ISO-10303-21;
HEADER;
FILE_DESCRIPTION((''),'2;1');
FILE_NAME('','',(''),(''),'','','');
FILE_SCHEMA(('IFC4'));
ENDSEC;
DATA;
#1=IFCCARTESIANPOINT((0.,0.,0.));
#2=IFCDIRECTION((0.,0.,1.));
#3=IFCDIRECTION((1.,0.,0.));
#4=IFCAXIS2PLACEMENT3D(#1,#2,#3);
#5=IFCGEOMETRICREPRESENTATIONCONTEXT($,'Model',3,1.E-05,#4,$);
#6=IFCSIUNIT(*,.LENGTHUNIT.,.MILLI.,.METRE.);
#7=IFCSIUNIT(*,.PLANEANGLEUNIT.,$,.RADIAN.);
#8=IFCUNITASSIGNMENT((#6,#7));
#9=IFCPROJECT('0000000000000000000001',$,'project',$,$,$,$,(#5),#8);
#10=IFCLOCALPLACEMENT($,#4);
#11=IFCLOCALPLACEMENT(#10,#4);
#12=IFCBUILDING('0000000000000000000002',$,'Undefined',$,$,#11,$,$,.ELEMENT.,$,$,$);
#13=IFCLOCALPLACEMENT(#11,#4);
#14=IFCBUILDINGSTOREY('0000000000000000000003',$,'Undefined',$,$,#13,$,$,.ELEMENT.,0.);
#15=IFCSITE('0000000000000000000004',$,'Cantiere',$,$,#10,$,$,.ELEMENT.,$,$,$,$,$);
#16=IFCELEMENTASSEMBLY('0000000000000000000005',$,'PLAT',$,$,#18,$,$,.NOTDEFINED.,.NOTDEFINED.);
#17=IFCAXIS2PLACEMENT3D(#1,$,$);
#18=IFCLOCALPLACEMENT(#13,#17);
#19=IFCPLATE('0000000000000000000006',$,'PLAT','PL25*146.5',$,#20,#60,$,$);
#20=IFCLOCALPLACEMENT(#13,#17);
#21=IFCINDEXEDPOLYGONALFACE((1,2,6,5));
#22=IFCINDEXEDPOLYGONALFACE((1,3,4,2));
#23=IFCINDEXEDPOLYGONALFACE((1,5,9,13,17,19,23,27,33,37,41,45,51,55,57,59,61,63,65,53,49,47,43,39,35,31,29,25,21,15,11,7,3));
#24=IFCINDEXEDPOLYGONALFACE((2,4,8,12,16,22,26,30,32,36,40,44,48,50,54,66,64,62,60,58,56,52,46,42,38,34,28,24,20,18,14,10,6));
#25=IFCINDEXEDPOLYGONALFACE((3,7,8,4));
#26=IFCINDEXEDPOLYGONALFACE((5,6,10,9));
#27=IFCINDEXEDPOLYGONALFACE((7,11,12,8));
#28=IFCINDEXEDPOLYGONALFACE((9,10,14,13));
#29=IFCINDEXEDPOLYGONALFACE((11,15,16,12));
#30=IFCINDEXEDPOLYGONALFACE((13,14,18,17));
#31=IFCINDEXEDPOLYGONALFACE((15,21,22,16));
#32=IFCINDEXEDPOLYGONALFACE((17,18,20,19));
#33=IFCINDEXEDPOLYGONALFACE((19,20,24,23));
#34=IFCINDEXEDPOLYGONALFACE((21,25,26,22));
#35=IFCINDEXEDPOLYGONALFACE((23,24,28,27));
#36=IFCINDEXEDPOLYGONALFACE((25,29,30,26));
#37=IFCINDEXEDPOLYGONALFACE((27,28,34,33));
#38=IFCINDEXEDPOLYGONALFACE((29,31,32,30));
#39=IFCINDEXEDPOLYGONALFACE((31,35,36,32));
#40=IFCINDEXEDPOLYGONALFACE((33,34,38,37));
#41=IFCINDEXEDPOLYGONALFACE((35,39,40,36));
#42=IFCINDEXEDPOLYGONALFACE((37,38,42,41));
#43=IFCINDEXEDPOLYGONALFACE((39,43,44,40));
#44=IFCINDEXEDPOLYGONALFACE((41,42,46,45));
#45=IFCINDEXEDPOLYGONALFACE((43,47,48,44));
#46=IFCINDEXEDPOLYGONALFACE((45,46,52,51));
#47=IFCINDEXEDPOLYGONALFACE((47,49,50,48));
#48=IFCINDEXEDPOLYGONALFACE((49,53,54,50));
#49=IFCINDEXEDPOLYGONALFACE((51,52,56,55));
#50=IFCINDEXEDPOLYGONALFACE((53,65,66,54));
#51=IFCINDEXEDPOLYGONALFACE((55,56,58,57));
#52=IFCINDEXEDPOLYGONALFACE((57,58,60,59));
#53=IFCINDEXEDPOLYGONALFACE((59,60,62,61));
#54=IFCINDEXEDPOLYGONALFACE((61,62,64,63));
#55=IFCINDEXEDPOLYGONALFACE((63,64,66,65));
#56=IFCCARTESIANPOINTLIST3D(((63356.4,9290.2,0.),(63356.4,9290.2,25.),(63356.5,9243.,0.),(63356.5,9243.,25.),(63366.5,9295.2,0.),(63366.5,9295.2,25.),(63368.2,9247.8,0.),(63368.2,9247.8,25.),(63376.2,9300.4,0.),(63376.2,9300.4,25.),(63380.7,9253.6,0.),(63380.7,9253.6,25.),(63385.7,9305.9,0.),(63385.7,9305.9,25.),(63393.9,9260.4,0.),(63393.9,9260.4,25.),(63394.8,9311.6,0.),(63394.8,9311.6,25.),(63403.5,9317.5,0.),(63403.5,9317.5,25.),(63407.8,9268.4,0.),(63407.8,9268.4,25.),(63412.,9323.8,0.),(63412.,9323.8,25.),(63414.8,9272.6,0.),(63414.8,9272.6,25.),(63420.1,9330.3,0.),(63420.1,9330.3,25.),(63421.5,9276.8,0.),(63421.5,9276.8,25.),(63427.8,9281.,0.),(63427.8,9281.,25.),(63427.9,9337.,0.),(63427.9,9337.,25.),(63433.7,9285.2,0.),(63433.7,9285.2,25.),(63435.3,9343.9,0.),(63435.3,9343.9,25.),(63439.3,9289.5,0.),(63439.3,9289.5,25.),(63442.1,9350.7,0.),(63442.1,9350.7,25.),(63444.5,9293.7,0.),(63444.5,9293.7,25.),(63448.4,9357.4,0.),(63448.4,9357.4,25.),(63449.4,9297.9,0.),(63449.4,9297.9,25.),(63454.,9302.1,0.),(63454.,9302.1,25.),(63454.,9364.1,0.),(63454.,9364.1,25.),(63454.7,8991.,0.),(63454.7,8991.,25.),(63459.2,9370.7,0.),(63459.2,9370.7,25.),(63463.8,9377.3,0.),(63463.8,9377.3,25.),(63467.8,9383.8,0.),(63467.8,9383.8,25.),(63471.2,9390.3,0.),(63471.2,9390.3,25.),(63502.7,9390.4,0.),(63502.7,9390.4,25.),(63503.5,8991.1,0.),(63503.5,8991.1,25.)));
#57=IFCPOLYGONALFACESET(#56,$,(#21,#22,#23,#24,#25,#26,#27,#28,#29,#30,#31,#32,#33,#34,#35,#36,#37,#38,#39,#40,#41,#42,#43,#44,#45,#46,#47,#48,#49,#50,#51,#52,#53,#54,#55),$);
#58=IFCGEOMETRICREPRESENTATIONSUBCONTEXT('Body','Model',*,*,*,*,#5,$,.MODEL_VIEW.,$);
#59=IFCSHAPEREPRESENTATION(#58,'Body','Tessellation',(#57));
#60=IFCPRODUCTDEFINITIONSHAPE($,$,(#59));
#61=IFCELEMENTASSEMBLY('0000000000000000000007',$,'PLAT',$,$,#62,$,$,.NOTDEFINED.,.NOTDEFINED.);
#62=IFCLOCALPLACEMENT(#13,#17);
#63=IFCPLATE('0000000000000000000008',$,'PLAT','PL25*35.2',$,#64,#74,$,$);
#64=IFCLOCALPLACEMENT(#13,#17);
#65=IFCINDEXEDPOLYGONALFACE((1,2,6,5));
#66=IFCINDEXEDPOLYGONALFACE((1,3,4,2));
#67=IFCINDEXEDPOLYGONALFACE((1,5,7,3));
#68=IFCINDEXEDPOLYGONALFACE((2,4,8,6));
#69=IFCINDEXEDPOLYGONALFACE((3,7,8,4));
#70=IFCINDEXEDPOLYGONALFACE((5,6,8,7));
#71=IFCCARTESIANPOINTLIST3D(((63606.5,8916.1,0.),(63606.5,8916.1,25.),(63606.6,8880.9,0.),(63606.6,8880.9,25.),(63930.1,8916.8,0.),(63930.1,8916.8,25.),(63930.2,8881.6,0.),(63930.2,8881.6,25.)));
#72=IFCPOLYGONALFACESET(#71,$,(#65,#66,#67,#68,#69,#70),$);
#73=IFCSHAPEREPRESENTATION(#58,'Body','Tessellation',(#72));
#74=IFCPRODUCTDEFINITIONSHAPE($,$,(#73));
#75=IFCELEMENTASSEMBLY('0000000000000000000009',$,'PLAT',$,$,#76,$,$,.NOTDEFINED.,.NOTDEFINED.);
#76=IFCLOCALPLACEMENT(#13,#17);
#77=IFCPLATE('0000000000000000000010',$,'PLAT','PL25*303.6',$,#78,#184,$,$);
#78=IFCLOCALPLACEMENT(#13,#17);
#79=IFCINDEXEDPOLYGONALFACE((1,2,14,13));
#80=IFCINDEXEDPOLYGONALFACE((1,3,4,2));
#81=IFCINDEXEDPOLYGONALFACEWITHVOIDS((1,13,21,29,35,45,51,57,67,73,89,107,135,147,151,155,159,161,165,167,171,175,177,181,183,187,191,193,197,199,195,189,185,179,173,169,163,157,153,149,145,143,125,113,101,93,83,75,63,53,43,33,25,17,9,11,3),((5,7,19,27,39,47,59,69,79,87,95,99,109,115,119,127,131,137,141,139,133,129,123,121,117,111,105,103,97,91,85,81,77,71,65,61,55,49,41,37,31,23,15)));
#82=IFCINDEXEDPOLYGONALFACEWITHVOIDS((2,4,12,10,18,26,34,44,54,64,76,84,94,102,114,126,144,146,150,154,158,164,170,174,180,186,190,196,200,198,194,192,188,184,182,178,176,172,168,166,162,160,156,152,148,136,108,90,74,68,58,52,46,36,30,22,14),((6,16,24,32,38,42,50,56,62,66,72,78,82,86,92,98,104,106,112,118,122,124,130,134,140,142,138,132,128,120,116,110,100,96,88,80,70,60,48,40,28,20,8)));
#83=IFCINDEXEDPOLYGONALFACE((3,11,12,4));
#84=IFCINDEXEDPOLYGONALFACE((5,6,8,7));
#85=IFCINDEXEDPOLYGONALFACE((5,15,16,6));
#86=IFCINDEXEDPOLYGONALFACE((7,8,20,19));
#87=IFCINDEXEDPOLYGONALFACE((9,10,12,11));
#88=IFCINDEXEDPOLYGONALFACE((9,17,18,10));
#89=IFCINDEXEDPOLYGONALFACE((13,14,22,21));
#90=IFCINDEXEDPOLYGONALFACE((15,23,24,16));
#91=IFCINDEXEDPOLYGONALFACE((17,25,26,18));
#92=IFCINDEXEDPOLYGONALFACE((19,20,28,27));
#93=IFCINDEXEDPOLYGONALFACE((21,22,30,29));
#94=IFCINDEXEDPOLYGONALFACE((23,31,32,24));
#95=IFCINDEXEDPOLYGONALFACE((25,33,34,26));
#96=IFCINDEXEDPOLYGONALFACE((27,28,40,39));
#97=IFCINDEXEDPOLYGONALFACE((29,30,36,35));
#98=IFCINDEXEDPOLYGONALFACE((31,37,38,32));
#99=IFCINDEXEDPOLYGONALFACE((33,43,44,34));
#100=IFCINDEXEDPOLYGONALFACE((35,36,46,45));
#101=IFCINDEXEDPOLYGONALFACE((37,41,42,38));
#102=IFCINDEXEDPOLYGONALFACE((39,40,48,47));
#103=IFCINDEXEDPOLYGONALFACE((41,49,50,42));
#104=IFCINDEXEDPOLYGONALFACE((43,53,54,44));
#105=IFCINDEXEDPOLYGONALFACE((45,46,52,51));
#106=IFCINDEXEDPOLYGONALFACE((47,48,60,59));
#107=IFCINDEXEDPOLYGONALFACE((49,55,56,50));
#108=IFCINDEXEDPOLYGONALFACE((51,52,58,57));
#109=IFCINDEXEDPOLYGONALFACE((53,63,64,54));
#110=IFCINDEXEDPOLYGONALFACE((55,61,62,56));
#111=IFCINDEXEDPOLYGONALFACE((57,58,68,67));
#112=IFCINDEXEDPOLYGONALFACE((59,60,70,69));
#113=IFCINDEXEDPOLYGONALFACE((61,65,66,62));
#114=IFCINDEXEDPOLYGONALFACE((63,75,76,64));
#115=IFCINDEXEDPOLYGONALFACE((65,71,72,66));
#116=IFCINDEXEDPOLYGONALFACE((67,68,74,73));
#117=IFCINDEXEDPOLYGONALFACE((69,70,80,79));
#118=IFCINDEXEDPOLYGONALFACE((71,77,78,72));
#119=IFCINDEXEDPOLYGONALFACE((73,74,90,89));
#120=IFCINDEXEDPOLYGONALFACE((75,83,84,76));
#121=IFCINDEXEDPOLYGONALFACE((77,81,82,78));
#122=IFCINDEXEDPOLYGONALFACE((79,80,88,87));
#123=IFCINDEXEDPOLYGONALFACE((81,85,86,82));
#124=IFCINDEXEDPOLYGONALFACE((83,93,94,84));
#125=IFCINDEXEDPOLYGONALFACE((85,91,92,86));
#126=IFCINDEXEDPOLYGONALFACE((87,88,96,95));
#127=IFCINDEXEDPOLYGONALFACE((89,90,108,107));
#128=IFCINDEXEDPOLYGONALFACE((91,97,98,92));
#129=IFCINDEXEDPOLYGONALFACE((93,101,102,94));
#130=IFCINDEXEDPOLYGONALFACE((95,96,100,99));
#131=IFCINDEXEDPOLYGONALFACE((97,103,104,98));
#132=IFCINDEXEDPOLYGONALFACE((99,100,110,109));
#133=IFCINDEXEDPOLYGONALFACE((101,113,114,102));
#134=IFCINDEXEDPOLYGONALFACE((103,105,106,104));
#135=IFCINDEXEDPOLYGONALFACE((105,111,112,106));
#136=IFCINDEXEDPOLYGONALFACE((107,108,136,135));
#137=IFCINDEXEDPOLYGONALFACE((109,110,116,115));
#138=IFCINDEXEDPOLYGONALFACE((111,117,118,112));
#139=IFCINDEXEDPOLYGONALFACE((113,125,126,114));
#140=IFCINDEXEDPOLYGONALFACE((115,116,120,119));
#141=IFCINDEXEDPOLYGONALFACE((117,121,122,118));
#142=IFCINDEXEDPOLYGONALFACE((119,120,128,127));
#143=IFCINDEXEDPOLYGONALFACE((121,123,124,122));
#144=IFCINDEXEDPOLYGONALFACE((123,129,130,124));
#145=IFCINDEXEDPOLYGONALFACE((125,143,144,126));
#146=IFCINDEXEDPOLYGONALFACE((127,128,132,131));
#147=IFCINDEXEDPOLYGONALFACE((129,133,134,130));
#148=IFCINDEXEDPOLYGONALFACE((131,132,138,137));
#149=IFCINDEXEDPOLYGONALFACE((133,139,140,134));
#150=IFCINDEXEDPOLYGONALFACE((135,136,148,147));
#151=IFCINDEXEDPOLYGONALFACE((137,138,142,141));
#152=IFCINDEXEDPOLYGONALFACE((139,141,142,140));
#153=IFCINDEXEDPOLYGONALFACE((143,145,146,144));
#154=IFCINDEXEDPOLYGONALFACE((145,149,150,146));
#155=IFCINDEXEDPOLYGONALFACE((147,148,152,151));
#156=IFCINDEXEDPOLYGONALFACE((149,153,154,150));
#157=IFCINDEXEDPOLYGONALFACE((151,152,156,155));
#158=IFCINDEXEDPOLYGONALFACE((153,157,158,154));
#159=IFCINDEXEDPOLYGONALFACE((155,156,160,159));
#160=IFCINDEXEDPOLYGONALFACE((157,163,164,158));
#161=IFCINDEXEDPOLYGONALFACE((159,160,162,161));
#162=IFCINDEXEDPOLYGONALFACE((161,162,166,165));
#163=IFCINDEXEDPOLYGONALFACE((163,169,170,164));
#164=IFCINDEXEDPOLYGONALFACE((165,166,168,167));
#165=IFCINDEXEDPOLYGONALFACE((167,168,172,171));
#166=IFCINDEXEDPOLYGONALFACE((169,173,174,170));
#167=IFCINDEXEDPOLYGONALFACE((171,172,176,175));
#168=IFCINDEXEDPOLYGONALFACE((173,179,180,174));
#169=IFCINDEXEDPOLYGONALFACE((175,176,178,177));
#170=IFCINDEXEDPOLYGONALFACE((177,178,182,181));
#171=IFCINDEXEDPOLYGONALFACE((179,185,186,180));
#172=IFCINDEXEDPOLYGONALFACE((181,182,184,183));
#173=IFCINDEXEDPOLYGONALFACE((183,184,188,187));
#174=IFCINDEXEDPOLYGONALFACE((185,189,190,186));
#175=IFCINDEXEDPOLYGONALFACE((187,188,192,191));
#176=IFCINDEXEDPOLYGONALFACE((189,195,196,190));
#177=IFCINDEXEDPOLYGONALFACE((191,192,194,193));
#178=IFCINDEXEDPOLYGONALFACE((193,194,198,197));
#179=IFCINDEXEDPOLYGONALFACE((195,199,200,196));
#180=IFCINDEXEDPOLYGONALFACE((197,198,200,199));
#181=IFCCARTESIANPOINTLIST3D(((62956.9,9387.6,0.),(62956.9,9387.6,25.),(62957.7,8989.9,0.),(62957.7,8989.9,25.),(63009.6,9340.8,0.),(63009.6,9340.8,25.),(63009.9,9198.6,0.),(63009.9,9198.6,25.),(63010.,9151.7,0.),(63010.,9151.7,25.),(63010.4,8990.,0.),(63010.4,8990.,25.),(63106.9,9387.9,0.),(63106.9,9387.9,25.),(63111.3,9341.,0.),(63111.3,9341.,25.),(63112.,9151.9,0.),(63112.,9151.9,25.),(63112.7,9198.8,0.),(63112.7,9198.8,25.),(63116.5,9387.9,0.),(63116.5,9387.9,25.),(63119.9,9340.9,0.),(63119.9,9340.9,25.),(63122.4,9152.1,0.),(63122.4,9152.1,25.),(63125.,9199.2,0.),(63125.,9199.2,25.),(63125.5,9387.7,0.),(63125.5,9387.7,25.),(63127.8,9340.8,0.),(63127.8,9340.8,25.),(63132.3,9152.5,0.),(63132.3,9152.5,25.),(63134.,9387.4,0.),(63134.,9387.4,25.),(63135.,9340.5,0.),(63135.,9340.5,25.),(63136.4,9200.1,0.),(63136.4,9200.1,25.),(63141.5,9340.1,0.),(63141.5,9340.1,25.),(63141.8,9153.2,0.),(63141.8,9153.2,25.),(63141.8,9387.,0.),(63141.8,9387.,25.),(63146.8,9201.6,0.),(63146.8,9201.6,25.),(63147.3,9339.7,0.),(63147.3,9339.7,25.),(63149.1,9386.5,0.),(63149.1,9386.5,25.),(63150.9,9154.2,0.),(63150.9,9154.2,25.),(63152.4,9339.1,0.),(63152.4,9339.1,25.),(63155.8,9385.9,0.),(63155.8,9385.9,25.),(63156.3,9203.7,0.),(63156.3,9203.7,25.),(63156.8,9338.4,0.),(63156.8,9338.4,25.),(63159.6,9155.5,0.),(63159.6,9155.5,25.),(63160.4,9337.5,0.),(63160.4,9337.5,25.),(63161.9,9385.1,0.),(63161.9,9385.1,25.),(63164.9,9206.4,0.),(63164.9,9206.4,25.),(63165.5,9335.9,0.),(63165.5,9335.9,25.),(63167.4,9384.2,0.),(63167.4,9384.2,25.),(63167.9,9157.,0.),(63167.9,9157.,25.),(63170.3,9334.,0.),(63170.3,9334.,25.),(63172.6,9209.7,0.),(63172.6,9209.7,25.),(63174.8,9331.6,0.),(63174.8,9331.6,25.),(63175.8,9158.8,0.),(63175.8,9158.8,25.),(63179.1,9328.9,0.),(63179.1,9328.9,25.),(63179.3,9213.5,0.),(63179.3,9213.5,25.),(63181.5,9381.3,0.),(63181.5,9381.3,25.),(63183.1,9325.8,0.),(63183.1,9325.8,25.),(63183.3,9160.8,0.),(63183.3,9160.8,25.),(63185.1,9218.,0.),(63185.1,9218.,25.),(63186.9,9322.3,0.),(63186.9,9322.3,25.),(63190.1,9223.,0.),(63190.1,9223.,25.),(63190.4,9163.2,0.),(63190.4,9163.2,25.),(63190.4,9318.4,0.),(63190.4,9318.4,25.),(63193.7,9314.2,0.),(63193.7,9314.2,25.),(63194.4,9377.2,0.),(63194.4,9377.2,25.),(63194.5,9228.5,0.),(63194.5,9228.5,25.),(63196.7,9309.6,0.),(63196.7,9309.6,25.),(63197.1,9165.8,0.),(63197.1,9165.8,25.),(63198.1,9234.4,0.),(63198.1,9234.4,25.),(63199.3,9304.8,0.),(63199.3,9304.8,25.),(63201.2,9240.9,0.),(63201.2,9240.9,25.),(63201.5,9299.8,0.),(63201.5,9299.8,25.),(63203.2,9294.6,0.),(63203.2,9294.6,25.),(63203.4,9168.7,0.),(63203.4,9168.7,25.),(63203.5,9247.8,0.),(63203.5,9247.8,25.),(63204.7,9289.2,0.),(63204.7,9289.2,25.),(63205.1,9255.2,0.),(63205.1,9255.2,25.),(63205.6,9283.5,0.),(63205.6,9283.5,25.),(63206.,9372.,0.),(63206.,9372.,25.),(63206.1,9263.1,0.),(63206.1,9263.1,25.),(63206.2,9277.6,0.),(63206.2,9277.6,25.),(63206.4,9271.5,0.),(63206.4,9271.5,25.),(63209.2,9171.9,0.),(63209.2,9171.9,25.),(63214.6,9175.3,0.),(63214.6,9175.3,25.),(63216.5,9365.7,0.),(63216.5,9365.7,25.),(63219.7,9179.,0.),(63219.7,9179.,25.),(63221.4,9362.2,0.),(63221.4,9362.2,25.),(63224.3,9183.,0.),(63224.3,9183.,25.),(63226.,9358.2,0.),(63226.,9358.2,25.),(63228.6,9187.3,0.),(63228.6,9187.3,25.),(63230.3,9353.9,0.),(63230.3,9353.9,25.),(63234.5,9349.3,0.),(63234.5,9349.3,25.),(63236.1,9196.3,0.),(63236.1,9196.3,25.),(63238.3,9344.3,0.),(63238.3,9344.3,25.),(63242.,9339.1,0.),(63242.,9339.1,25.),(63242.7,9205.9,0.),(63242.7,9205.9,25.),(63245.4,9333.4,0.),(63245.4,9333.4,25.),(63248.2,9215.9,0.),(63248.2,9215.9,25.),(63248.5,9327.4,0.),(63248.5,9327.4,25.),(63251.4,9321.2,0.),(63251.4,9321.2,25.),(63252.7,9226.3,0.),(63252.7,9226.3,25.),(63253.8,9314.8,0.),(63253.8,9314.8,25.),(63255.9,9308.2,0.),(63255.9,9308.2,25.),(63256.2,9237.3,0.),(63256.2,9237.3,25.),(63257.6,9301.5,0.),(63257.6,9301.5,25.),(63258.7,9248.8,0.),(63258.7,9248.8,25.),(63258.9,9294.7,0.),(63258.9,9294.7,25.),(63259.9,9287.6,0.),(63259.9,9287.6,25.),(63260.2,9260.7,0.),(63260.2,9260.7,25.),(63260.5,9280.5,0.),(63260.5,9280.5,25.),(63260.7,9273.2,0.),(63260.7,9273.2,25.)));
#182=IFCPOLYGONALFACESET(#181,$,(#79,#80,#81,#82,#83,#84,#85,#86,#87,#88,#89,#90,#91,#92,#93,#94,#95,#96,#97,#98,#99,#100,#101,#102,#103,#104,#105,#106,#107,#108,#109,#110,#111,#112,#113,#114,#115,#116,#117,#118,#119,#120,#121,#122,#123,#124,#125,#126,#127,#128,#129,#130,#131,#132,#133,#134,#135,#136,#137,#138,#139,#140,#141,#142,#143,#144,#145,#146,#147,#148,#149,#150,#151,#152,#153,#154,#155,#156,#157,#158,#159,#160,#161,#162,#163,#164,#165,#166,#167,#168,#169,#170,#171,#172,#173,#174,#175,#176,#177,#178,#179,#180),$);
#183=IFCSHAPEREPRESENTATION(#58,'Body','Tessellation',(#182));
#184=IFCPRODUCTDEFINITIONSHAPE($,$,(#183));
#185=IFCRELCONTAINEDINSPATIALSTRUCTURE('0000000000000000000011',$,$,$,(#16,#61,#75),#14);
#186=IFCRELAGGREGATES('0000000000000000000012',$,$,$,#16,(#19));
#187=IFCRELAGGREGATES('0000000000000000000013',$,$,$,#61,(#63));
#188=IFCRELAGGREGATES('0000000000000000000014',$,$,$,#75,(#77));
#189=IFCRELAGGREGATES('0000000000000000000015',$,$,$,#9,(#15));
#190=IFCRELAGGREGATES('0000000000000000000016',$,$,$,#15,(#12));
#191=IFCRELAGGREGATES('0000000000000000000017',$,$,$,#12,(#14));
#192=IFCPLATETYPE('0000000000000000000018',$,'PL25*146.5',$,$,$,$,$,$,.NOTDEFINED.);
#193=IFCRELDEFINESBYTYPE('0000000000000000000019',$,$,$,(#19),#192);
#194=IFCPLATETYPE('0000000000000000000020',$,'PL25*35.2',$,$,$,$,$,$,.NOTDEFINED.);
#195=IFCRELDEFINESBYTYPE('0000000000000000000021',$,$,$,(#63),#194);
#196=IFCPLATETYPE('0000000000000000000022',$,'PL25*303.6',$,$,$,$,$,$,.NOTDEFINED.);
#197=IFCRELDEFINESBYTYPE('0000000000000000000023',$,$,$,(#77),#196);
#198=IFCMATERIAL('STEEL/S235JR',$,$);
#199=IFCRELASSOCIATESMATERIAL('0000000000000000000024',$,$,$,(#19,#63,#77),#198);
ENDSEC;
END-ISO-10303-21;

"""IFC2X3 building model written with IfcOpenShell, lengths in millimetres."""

from ifc_helpers import new_model, si_unit, frame, origin_with_axes, place, context, subcontext, project, spatial, polyline, outline, extrude, boolean, material, type_object, element, aggregate, save


model = new_model("IFC2X3")

# Units and contexts
model_context = context("Model", 3, precision=1e-05, world=origin_with_axes())
body_context = subcontext(model_context, "Body", "Model", "MODEL_VIEW")
ifc_project = project(units=[si_unit("LENGTHUNIT", "METRE", prefix="MILLI"), si_unit("PLANEANGLEUNIT", "RADIAN")], contexts=[model_context])

# Site, building, storey
site_placement = place(None, origin_with_axes())
site = spatial("IfcSite", under=ifc_project, at=site_placement, Name="Cantiere", CompositionType="ELEMENT")
building_placement = place(site_placement, origin_with_axes())
building = spatial("IfcBuilding", under=site, at=building_placement, Name="Undefined", CompositionType="ELEMENT")
storey_placement = place(building_placement, origin_with_axes())
storey = spatial("IfcBuildingStorey", under=building, at=storey_placement, Name="Undefined", CompositionType="ELEMENT", Elevation=0.0)

# Shared definitions
ifc_material_1 = material(Name="STEEL/S235JR")

# Element assemblies, plates
assembly_1_placement = place(storey_placement, origin_with_axes())
assembly_1 = element("IfcElementAssembly", 1, at=assembly_1_placement, inside=storey, Name="PLAT", AssemblyPlace="NOTDEFINED", PredefinedType="NOTDEFINED")
plate_type_1 = type_object("IfcPlateType", Name="PL25*146.5", PredefinedType="NOTDEFINED")
plate_1_placement = place(assembly_1_placement, frame((63503.5, 8991.1, 12.5), z_axis=(0.0, 0.000001, -1.0), x_axis=(-0.999998, -0.00212, 0.0)))
plate_1 = element("IfcPlate", 2, at=plate_1_placement, type_object=plate_type_1, material=ifc_material_1, Name="PLAT", Description="PL25*146.5", context=body_context, shape_type="SweptSolid", body=[
    extrude(outline(polyline([(0.0, 0.0), (48.9, 0.0), (48.9, 311.2), (53.5, 307.0), (58.4, 302.7), (63.6, 298.6), (69.2, 294.3), (75.1, 290.1), (81.5, 285.9), (88.1, 281.7), (95.1, 277.5), (109.0, 269.6), (122.3, 262.8), (134.8, 257.0), (146.5, 252.3), (146.5, 299.5), (136.4, 304.5), (126.7, 309.6), (117.2, 315.1), (108.1, 320.7), (99.3, 326.7), (90.9, 333.0), (82.7, 339.4), (74.9, 346.2), (67.5, 353.0), (60.6, 359.8), (54.4, 366.5), (48.7, 373.2), (43.5, 379.8), (39.0, 386.4), (34.9, 392.9), (31.5, 399.3), (0.0, 399.3), (0.0, 0.0)])), frame((0.0, 0.0, -12.5), z_axis=(0.0, 0.0, 1.0), x_axis=(1.0, 0.0, 0.0)), (0.0, 0.0, 1.0), 25.0),
])
aggregate(assembly_1, [plate_1])
assembly_2_placement = place(storey_placement, origin_with_axes())
assembly_2 = element("IfcElementAssembly", 3, at=assembly_2_placement, inside=storey, Name="PLAT", AssemblyPlace="NOTDEFINED", PredefinedType="NOTDEFINED")
plate_type_2 = type_object("IfcPlateType", Name="PL25*35.2", PredefinedType="NOTDEFINED")
plate_2_placement = place(assembly_2_placement, frame((63606.6, 8880.9, 12.5), z_axis=(0.0, 0.000001, -1.0), x_axis=(-0.00212, 0.999998, 0.0)))
plate_2 = element("IfcPlate", 4, at=plate_2_placement, type_object=plate_type_2, material=ifc_material_1, Name="PLAT", Description="PL25*35.2", context=body_context, shape_type="SweptSolid", body=[
    extrude(outline(polyline([(0.0, 0.0), (35.2, 0.0), (35.2, 323.7), (0.0, 323.7), (0.0, 0.0)])), frame((0.0, 0.0, -12.5), z_axis=(0.0, 0.0, 1.0), x_axis=(1.0, 0.0, 0.0)), (0.0, 0.0, 1.0), 25.0),
])
aggregate(assembly_2, [plate_2])
assembly_3_placement = place(storey_placement, origin_with_axes())
assembly_3 = element("IfcElementAssembly", 5, at=assembly_3_placement, inside=storey, Name="PLAT", AssemblyPlace="NOTDEFINED", PredefinedType="NOTDEFINED")
plate_type_3 = type_object("IfcPlateType", Name="PL25*303.6", PredefinedType="NOTDEFINED")
plate_3_placement = place(assembly_3_placement, frame((62957.7, 8989.9, 12.5), z_axis=(0.0, 0.000001, -1.0), x_axis=(-0.00212, 0.999998, 0.0)))
plate_3 = element("IfcPlate", 6, at=plate_3_placement, type_object=plate_type_3, material=ifc_material_1, Name="PLAT", Description="PL25*303.6", context=body_context, shape_type="CSG", body=[
    boolean("DIFFERENCE", extrude(outline(polyline([(0.0, 0.0), (397.7, 0.0), (397.7, 150.0), (397.7, 159.6), (397.5, 168.7), (397.2, 177.1), (396.8, 185.0), (396.2, 192.2), (395.6, 198.9), (394.8, 205.0), (393.9, 210.5), (390.9, 224.6), (386.8, 237.5), (381.6, 249.1), (375.3, 259.6), (371.7, 264.5), (367.8, 269.0), (363.5, 273.4), (358.9, 277.5), (353.9, 281.4), (348.6, 285.0), (342.9, 288.4), (336.9, 291.5), (330.7, 294.4), (324.3, 296.8), (317.7, 298.9), (311.0, 300.6), (304.2, 301.9), (297.1, 302.8), (290.0, 303.4), (282.7, 303.6), (270.2, 303.1), (258.3, 301.6), (246.8, 299.0), (235.8, 295.5), (225.3, 291.0), (215.3, 285.4), (205.8, 278.9), (196.8, 271.3), (192.5, 267.0), (188.5, 262.4), (184.8, 257.3), (181.5, 251.9), (178.3, 246.0), (175.4, 239.8), (172.8, 233.1), (170.4, 226.0), (168.4, 218.5), (166.6, 210.6), (165.1, 202.3), (163.9, 193.6), (162.9, 184.5), (162.2, 174.9), (161.8, 165.0), (161.7, 154.7), (161.7, 52.7), (0.0, 52.7), (0.0, 0.0)])), frame((0.0, 0.0, -12.5), z_axis=(0.0, 0.0, 1.0), x_axis=(1.0, 0.0, 0.0)), (0.0, 0.0, 1.0), 25.0), extrude(outline(polyline([(0.0, 0.0), (102.8, 0.0), (115.1, 0.3), (126.5, 1.2), (136.9, 2.7), (146.4, 4.8), (155.0, 7.5), (162.7, 10.7), (169.4, 14.6), (175.2, 19.0), (180.3, 24.0), (184.6, 29.5), (188.3, 35.4), (191.3, 41.9), (193.7, 48.8), (195.3, 56.2), (196.3, 64.1), (196.7, 72.5), (196.5, 78.6), (195.9, 84.5), (194.9, 90.2), (193.5, 95.6), (191.8, 100.8), (189.5, 105.8), (187.0, 110.6), (184.0, 115.2), (180.8, 119.4), (177.3, 123.3), (173.5, 126.8), (169.5, 129.9), (165.2, 132.7), (160.6, 135.0), (155.9, 137.0), (150.8, 138.6), (147.2, 139.5), (142.8, 140.2), (137.7, 140.8), (131.9, 141.3), (125.4, 141.7), (118.2, 142.0), (110.3, 142.1), (101.7, 142.2), (0.0, 142.2), (0.0, 0.0)])), frame((208.6, 52.7, 12.5), z_axis=(0.0, 0.000001, -1.0), x_axis=(0.0, 1.0, 0.0)), (0.0, 0.0, 1.0), 25.0)),
])
aggregate(assembly_3, [plate_3])

save(model, "model.ifc")
